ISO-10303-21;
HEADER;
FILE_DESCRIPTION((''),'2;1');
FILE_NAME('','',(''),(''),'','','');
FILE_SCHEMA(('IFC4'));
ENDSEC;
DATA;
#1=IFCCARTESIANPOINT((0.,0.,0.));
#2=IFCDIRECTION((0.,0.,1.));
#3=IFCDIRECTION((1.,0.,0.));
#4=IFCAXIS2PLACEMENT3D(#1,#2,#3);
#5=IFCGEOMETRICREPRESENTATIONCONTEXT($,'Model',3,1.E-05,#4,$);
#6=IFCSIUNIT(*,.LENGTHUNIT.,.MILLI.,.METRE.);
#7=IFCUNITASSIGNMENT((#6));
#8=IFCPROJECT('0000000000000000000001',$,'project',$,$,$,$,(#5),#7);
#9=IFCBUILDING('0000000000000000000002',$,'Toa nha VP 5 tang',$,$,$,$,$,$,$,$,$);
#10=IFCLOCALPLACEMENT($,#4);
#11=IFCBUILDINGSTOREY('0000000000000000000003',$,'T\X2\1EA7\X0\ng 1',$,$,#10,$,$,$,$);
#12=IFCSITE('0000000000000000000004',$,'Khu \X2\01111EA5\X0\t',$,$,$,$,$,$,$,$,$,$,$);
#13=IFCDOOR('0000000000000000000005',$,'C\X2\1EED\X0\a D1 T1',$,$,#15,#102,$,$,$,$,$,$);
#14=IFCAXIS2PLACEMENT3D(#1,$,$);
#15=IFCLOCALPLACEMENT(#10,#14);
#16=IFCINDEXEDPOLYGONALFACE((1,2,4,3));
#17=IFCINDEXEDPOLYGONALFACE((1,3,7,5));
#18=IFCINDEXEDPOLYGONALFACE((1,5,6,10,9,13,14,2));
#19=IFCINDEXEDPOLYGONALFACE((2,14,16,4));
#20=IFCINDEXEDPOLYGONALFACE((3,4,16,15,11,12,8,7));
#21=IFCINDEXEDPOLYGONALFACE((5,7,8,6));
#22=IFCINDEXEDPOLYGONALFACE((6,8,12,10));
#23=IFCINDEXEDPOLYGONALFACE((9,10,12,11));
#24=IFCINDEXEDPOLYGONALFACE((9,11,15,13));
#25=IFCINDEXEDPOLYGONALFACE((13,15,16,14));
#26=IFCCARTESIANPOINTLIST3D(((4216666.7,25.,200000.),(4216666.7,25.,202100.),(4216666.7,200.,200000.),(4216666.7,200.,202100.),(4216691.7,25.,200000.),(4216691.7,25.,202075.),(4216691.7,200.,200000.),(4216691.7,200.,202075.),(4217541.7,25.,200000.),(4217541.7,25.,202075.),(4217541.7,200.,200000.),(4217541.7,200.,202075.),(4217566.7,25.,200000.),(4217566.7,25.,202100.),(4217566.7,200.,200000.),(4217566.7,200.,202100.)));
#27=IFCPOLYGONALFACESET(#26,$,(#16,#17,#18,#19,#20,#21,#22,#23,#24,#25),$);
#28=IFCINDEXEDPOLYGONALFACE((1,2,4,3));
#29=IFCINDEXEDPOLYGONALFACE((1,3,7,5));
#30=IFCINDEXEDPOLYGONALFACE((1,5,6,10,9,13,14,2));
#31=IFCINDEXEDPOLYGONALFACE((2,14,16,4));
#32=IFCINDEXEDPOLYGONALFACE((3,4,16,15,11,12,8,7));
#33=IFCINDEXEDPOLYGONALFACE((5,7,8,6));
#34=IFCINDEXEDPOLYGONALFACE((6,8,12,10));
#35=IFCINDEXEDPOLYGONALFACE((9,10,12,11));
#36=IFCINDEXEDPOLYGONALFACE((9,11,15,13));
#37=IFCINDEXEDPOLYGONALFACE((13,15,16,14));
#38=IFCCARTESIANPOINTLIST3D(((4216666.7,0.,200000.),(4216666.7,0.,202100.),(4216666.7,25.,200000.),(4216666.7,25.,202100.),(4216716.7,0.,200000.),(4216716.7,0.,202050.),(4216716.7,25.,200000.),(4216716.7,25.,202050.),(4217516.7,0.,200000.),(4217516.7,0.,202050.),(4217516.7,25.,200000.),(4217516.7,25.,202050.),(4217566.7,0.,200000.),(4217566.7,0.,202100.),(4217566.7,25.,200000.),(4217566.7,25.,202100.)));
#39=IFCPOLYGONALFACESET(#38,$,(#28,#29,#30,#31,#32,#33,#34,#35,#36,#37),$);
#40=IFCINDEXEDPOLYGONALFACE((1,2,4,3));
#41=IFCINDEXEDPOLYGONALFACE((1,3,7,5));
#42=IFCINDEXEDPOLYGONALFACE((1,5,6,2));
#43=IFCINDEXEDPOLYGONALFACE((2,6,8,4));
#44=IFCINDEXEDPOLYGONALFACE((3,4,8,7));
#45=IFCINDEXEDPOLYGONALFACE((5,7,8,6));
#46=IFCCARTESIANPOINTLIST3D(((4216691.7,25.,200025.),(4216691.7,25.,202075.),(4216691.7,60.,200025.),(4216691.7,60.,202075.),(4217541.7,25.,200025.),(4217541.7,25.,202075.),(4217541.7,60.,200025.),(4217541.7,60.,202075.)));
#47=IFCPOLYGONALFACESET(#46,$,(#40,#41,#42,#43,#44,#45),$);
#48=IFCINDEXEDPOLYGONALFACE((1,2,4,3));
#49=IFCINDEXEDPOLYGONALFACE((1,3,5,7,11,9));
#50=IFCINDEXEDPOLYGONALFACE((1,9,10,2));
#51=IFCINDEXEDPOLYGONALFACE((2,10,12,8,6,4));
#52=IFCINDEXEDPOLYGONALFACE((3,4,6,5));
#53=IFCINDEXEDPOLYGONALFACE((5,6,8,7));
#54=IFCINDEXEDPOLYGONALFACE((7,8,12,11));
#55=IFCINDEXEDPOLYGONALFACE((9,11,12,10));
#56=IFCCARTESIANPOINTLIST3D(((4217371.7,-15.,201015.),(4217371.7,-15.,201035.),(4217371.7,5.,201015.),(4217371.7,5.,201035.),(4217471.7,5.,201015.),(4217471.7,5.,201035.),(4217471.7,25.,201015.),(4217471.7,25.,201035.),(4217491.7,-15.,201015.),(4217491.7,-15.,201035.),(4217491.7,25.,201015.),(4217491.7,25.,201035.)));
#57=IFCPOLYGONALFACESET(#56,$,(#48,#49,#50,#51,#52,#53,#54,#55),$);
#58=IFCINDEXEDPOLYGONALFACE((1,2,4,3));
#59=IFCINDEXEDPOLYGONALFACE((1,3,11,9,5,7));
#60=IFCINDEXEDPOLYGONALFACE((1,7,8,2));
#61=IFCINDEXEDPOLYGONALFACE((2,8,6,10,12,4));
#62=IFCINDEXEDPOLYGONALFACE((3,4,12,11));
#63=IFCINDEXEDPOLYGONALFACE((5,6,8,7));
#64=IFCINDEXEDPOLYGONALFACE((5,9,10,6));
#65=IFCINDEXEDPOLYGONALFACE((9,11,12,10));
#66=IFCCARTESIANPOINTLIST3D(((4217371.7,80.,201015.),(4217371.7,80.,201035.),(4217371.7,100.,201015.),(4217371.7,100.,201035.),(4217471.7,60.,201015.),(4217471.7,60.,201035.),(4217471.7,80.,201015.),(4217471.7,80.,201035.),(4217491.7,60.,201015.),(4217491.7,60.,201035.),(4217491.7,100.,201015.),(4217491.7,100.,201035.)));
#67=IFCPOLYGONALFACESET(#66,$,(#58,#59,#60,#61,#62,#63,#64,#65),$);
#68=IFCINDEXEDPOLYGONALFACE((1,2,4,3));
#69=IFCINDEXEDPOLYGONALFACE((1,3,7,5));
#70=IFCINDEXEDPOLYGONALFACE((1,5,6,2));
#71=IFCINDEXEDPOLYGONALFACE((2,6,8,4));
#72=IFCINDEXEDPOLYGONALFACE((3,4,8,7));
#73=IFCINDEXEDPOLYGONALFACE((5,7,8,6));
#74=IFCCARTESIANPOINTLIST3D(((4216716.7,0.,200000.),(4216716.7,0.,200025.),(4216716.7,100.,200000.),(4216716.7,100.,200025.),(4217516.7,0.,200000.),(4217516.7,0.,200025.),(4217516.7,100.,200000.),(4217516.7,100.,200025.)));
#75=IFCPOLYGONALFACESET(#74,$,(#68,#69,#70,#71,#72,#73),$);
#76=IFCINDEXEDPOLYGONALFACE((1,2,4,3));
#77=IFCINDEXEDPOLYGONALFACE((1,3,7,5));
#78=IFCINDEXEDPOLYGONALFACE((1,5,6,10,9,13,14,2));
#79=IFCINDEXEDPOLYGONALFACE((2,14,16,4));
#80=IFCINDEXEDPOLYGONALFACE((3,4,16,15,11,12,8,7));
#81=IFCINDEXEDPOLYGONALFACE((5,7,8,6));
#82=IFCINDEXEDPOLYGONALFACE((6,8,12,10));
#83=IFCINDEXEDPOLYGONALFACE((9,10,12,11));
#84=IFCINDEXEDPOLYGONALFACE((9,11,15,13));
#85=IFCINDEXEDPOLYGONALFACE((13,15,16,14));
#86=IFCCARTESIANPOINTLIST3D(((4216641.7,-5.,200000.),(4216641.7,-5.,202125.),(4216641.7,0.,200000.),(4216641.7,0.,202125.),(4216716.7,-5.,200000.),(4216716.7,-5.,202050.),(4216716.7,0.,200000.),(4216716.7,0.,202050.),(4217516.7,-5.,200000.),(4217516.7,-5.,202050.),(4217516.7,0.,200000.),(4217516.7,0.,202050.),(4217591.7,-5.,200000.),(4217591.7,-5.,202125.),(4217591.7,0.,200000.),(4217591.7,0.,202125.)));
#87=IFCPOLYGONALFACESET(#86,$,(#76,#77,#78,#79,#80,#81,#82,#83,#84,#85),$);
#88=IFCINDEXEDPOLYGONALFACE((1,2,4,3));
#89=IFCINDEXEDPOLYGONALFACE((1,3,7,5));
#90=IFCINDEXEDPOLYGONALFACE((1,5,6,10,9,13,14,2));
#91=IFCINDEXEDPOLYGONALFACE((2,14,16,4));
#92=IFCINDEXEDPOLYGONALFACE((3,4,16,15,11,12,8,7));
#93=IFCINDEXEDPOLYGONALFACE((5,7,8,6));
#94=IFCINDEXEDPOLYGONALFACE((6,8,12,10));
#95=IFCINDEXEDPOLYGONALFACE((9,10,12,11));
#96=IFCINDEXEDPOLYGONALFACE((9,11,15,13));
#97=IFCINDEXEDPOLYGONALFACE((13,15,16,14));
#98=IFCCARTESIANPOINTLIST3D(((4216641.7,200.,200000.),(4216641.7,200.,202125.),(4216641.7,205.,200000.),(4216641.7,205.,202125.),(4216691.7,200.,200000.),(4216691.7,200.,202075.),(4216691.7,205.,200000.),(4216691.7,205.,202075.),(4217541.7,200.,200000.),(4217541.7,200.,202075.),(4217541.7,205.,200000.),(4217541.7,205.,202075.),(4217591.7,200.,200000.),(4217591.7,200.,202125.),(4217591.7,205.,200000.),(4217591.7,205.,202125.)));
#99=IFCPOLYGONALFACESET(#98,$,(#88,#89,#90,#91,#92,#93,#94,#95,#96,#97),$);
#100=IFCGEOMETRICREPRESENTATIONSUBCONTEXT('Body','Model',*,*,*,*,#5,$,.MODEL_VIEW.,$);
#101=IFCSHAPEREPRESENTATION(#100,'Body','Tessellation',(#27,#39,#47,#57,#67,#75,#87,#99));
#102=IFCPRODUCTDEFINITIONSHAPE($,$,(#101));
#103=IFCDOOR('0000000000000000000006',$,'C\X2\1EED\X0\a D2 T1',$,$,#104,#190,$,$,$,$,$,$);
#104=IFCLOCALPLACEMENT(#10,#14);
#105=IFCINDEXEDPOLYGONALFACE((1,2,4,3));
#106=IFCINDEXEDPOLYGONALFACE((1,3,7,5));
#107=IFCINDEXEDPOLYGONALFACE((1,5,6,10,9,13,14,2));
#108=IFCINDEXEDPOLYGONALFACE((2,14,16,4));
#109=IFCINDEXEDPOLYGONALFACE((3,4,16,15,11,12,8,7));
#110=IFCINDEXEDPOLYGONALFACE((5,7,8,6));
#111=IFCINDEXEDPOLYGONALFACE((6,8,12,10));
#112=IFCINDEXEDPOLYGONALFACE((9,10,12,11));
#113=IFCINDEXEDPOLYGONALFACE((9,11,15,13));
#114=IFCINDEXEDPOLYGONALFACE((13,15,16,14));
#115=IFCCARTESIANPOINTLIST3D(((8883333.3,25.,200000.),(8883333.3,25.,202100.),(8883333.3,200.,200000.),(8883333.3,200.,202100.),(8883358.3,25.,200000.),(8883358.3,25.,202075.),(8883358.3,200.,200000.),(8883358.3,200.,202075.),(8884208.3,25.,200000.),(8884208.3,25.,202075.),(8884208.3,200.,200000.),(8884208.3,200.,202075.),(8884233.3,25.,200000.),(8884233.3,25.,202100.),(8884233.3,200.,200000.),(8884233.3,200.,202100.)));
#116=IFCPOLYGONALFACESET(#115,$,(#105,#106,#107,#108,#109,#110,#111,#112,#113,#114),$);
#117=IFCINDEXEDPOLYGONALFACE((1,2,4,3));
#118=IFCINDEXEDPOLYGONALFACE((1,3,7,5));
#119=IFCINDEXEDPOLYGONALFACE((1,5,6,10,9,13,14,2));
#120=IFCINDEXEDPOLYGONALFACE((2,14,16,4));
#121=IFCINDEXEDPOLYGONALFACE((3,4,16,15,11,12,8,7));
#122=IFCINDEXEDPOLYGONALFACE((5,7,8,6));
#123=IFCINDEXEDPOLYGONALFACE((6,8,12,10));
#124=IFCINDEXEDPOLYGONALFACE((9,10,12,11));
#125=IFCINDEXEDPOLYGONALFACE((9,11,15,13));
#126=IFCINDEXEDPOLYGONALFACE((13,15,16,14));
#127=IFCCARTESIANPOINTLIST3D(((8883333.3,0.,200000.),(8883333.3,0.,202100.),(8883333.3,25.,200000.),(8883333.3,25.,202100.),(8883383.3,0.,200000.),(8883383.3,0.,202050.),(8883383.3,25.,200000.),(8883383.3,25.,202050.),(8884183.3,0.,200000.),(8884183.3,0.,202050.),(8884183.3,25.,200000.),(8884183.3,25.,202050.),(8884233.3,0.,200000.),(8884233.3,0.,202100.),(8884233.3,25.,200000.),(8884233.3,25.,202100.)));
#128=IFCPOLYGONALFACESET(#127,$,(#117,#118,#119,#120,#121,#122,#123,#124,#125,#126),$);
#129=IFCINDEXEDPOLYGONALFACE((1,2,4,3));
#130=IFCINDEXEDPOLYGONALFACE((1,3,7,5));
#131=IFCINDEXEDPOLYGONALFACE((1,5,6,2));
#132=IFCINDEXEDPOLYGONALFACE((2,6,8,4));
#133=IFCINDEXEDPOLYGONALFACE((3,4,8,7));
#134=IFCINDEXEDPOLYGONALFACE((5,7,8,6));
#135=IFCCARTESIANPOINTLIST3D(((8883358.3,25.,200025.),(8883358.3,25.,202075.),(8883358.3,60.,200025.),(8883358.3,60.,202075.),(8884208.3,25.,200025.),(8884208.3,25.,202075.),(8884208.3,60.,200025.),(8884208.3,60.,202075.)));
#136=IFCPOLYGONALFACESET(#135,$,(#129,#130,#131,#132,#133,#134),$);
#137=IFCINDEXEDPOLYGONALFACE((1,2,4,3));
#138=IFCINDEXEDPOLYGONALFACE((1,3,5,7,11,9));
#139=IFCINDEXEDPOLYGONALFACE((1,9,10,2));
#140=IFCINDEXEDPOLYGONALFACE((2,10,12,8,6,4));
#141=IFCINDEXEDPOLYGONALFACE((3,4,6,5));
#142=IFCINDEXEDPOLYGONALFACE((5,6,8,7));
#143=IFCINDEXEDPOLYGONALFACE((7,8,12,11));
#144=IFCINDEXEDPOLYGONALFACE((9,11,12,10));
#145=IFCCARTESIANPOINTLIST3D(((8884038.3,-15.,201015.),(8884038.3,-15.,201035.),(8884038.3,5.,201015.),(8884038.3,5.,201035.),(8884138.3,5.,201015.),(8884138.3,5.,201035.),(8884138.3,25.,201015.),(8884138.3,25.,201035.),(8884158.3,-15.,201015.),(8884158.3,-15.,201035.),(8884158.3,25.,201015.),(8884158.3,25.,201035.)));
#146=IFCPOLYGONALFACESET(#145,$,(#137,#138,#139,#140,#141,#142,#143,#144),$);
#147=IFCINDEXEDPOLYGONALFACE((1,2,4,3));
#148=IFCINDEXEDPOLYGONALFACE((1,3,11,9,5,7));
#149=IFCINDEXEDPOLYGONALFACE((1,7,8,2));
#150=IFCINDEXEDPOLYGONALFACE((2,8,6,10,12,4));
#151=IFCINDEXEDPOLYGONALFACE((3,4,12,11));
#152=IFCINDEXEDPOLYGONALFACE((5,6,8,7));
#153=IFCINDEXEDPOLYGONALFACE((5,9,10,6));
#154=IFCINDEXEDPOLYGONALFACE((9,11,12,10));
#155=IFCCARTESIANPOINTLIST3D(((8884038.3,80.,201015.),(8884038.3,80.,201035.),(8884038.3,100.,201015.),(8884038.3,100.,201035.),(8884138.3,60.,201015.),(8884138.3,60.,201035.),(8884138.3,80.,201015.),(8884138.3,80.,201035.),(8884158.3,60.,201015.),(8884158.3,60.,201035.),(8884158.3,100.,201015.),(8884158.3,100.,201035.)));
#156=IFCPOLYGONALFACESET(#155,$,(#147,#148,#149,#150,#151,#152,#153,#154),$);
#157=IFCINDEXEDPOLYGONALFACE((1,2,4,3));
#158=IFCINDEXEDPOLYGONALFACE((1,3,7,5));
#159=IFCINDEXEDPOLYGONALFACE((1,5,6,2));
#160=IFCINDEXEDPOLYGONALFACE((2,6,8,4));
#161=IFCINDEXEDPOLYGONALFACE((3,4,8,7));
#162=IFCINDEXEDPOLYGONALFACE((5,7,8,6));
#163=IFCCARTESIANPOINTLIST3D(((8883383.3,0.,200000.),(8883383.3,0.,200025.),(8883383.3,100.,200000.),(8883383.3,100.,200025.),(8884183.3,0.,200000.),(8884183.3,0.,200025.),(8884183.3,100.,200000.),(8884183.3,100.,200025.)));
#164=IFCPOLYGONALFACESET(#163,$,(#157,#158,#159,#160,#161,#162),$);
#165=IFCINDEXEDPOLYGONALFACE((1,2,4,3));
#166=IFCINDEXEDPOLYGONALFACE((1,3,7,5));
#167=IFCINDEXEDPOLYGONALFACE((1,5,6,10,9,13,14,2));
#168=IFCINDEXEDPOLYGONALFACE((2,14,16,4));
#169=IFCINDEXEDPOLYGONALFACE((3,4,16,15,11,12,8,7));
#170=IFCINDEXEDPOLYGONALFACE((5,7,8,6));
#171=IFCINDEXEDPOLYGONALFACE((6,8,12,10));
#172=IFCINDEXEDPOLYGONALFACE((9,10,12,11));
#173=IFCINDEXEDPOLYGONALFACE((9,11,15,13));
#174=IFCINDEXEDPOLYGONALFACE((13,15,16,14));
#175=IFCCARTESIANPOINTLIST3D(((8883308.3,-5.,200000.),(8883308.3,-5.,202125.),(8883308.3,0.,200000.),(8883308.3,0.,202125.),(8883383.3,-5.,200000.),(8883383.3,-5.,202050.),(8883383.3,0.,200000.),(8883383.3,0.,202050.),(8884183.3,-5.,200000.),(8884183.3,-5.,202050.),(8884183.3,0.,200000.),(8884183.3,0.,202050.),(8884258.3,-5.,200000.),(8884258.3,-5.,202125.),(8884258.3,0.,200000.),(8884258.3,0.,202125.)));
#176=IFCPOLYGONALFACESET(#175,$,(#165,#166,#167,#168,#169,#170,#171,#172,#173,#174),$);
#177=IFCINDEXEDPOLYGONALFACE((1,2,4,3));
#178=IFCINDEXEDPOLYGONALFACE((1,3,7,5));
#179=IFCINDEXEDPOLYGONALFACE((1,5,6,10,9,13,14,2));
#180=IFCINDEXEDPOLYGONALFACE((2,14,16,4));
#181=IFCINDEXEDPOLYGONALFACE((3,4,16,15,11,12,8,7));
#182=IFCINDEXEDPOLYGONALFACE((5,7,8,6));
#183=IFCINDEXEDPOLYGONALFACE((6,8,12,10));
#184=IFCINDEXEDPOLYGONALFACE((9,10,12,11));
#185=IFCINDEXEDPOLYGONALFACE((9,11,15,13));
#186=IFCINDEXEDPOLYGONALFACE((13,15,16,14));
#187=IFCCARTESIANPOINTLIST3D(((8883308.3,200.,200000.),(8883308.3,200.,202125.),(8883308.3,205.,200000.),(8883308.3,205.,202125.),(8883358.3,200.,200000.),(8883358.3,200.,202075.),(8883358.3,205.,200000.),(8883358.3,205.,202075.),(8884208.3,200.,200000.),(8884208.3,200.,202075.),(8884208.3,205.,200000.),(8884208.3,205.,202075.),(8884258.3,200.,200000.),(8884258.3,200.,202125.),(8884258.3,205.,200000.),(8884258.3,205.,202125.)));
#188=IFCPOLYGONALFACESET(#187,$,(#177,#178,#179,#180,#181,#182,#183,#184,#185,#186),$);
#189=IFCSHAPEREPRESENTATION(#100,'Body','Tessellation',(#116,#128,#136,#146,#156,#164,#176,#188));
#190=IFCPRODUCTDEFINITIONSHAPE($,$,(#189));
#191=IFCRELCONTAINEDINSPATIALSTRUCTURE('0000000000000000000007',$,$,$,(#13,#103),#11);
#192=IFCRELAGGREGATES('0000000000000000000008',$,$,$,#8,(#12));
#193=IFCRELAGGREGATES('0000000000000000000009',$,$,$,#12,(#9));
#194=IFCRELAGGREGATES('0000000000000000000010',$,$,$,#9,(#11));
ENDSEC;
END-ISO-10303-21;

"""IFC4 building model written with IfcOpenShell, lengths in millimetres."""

from ifc_helpers import new_model, si_unit, frame, origin_with_axes, place, context, subcontext, project, spatial, line, indexed_curve, outline, extrude, element, save


model = new_model("IFC4")

# Units and contexts
model_context = context("Model", 3, precision=1e-05, world=origin_with_axes())
body_context = subcontext(model_context, "Body", "Model", "MODEL_VIEW")
ifc_project = project(units=[si_unit("LENGTHUNIT", "METRE", prefix="MILLI")], contexts=[model_context])

# Site, building, storey
site = spatial("IfcSite", under=ifc_project, Name="Khu đất")
building = spatial("IfcBuilding", under=site, Name="Toa nha VP 5 tang")
storey_placement = place(None, origin_with_axes())
storey = spatial("IfcBuildingStorey", under=building, at=storey_placement, Name="Tầng 1")

# Doors
door_1_placement = place(storey_placement, frame((4216666.7, 0.0, 200000.0), z_axis=(0.0, 0.0, 1.0), x_axis=(1.0, 0.0, 0.0)))
element("IfcDoor", 1, at=door_1_placement, inside=storey, Name="Cửa D1 T1", context=body_context, shape_type="SolidModel", body=[
    extrude(outline(indexed_curve([(0.0, 0.0), (0.0, 2100.0), (900.0, 2100.0), (900.0, 0.0), (875.0, 0.0), (875.0, 2075.0), (25.0, 2075.0), (25.0, 0.0)], segments=[line(1, 2, 3, 4, 5, 6, 7, 8, 1)])), frame((0.0, 25.0, 0.0), z_axis=(0.0, -1.0, 0.0), x_axis=(1.0, 0.0, 0.0)), (0.0, 0.0, -1.0), 175.0),
    extrude(outline(indexed_curve([(0.0, 0.0), (0.0, 2100.0), (900.0, 2100.0), (900.0, 0.0), (850.0, 0.0), (850.0, 2050.0), (50.0, 2050.0), (50.0, 0.0)], segments=[line(1, 2, 3, 4, 5, 6, 7, 8, 1)])), frame((0.0, 0.0, 0.0), z_axis=(0.0, -1.0, 0.0), x_axis=(1.0, 0.0, 0.0)), (0.0, 0.0, -1.0), 25.0),
    extrude(outline(indexed_curve([(0.0, 0.0), (850.0, 0.0), (850.0, 35.0), (0.0, 35.0)], segments=[line(1, 2, 3, 4, 1)])), frame((25.0, 25.0, 25.0), z_axis=(0.0, 0.0, 1.0), x_axis=(1.0, 0.0, 0.0)), (0.0, 0.0, 1.0), 2050.0),
    extrude(outline(indexed_curve([(0.0, 0.0), (0.0, -40.0), (-120.0, -40.0), (-120.0, -20.0), (-20.0, -20.0), (-20.0, 0.0)], segments=[line(1, 2, 3, 4, 5, 6, 1)])), frame((825.0, 25.0, 1015.0), z_axis=(0.0, 0.0, 1.0), x_axis=(1.0, 0.0, 0.0)), (0.0, 0.0, 1.0), 20.0),
    extrude(outline(indexed_curve([(0.0, 0.0), (0.0, 40.0), (-120.0, 40.0), (-120.0, 20.0), (-20.0, 20.0), (-20.0, 0.0)], segments=[line(1, 2, 3, 4, 5, 6, 1)])), frame((825.0, 60.0, 1015.0), z_axis=(0.0, 0.0, 1.0), x_axis=(1.0, 0.0, 0.0)), (0.0, 0.0, 1.0), 20.0),
    extrude(outline(indexed_curve([(0.0, 0.0), (800.0, 0.0), (800.0, 100.0), (0.0, 100.0)], segments=[line(1, 2, 3, 4, 1)])), frame((50.0, 0.0, 0.0), z_axis=(0.0, 0.0, 1.0), x_axis=(1.0, 0.0, 0.0)), (0.0, 0.0, 1.0), 25.0),
    extrude(outline(indexed_curve([(0.0, 0.0), (0.0, 2125.0), (950.0, 2125.0), (950.0, 0.0), (875.0, 0.0), (875.0, 2050.0), (75.0, 2050.0), (75.0, 0.0)], segments=[line(1, 2, 3, 4, 5, 6, 7, 8, 1)])), frame((-25.0, -5.0, 0.0), z_axis=(0.0, -1.0, 0.0), x_axis=(1.0, 0.0, 0.0)), (0.0, 0.0, -1.0), 5.0),
    extrude(outline(indexed_curve([(0.0, 0.0), (0.0, 2125.0), (950.0, 2125.0), (950.0, 0.0), (900.0, 0.0), (900.0, 2075.0), (50.0, 2075.0), (50.0, 0.0)], segments=[line(1, 2, 3, 4, 5, 6, 7, 8, 1)])), frame((-25.0, 200.0, 0.0), z_axis=(0.0, -1.0, 0.0), x_axis=(1.0, 0.0, 0.0)), (0.0, 0.0, -1.0), 5.0),
])
door_2_placement = place(storey_placement, frame((8883333.3, 0.0, 200000.0), z_axis=(0.0, 0.0, 1.0), x_axis=(1.0, 0.0, 0.0)))
element("IfcDoor", 2, at=door_2_placement, inside=storey, Name="Cửa D2 T1", context=body_context, shape_type="SolidModel", body=[
    extrude(outline(indexed_curve([(0.0, 0.0), (0.0, 2100.0), (900.0, 2100.0), (900.0, 0.0), (875.0, 0.0), (875.0, 2075.0), (25.0, 2075.0), (25.0, 0.0)], segments=[line(1, 2, 3, 4, 5, 6, 7, 8, 1)])), frame((0.0, 25.0, 0.0), z_axis=(0.0, -1.0, 0.0), x_axis=(1.0, 0.0, 0.0)), (0.0, 0.0, -1.0), 175.0),
    extrude(outline(indexed_curve([(0.0, 0.0), (0.0, 2100.0), (900.0, 2100.0), (900.0, 0.0), (850.0, 0.0), (850.0, 2050.0), (50.0, 2050.0), (50.0, 0.0)], segments=[line(1, 2, 3, 4, 5, 6, 7, 8, 1)])), frame((0.0, 0.0, 0.0), z_axis=(0.0, -1.0, 0.0), x_axis=(1.0, 0.0, 0.0)), (0.0, 0.0, -1.0), 25.0),
    extrude(outline(indexed_curve([(0.0, 0.0), (850.0, 0.0), (850.0, 35.0), (0.0, 35.0)], segments=[line(1, 2, 3, 4, 1)])), frame((25.0, 25.0, 25.0), z_axis=(0.0, 0.0, 1.0), x_axis=(1.0, 0.0, 0.0)), (0.0, 0.0, 1.0), 2050.0),
    extrude(outline(indexed_curve([(0.0, 0.0), (0.0, -40.0), (-120.0, -40.0), (-120.0, -20.0), (-20.0, -20.0), (-20.0, 0.0)], segments=[line(1, 2, 3, 4, 5, 6, 1)])), frame((825.0, 25.0, 1015.0), z_axis=(0.0, 0.0, 1.0), x_axis=(1.0, 0.0, 0.0)), (0.0, 0.0, 1.0), 20.0),
    extrude(outline(indexed_curve([(0.0, 0.0), (0.0, 40.0), (-120.0, 40.0), (-120.0, 20.0), (-20.0, 20.0), (-20.0, 0.0)], segments=[line(1, 2, 3, 4, 5, 6, 1)])), frame((825.0, 60.0, 1015.0), z_axis=(0.0, 0.0, 1.0), x_axis=(1.0, 0.0, 0.0)), (0.0, 0.0, 1.0), 20.0),
    extrude(outline(indexed_curve([(0.0, 0.0), (800.0, 0.0), (800.0, 100.0), (0.0, 100.0)], segments=[line(1, 2, 3, 4, 1)])), frame((50.0, 0.0, 0.0), z_axis=(0.0, 0.0, 1.0), x_axis=(1.0, 0.0, 0.0)), (0.0, 0.0, 1.0), 25.0),
    extrude(outline(indexed_curve([(0.0, 0.0), (0.0, 2125.0), (950.0, 2125.0), (950.0, 0.0), (875.0, 0.0), (875.0, 2050.0), (75.0, 2050.0), (75.0, 0.0)], segments=[line(1, 2, 3, 4, 5, 6, 7, 8, 1)])), frame((-25.0, -5.0, 0.0), z_axis=(0.0, -1.0, 0.0), x_axis=(1.0, 0.0, 0.0)), (0.0, 0.0, -1.0), 5.0),
    extrude(outline(indexed_curve([(0.0, 0.0), (0.0, 2125.0), (950.0, 2125.0), (950.0, 0.0), (900.0, 0.0), (900.0, 2075.0), (50.0, 2075.0), (50.0, 0.0)], segments=[line(1, 2, 3, 4, 5, 6, 7, 8, 1)])), frame((-25.0, 200.0, 0.0), z_axis=(0.0, -1.0, 0.0), x_axis=(1.0, 0.0, 0.0)), (0.0, 0.0, -1.0), 5.0),
])

save(model, "model.ifc")
